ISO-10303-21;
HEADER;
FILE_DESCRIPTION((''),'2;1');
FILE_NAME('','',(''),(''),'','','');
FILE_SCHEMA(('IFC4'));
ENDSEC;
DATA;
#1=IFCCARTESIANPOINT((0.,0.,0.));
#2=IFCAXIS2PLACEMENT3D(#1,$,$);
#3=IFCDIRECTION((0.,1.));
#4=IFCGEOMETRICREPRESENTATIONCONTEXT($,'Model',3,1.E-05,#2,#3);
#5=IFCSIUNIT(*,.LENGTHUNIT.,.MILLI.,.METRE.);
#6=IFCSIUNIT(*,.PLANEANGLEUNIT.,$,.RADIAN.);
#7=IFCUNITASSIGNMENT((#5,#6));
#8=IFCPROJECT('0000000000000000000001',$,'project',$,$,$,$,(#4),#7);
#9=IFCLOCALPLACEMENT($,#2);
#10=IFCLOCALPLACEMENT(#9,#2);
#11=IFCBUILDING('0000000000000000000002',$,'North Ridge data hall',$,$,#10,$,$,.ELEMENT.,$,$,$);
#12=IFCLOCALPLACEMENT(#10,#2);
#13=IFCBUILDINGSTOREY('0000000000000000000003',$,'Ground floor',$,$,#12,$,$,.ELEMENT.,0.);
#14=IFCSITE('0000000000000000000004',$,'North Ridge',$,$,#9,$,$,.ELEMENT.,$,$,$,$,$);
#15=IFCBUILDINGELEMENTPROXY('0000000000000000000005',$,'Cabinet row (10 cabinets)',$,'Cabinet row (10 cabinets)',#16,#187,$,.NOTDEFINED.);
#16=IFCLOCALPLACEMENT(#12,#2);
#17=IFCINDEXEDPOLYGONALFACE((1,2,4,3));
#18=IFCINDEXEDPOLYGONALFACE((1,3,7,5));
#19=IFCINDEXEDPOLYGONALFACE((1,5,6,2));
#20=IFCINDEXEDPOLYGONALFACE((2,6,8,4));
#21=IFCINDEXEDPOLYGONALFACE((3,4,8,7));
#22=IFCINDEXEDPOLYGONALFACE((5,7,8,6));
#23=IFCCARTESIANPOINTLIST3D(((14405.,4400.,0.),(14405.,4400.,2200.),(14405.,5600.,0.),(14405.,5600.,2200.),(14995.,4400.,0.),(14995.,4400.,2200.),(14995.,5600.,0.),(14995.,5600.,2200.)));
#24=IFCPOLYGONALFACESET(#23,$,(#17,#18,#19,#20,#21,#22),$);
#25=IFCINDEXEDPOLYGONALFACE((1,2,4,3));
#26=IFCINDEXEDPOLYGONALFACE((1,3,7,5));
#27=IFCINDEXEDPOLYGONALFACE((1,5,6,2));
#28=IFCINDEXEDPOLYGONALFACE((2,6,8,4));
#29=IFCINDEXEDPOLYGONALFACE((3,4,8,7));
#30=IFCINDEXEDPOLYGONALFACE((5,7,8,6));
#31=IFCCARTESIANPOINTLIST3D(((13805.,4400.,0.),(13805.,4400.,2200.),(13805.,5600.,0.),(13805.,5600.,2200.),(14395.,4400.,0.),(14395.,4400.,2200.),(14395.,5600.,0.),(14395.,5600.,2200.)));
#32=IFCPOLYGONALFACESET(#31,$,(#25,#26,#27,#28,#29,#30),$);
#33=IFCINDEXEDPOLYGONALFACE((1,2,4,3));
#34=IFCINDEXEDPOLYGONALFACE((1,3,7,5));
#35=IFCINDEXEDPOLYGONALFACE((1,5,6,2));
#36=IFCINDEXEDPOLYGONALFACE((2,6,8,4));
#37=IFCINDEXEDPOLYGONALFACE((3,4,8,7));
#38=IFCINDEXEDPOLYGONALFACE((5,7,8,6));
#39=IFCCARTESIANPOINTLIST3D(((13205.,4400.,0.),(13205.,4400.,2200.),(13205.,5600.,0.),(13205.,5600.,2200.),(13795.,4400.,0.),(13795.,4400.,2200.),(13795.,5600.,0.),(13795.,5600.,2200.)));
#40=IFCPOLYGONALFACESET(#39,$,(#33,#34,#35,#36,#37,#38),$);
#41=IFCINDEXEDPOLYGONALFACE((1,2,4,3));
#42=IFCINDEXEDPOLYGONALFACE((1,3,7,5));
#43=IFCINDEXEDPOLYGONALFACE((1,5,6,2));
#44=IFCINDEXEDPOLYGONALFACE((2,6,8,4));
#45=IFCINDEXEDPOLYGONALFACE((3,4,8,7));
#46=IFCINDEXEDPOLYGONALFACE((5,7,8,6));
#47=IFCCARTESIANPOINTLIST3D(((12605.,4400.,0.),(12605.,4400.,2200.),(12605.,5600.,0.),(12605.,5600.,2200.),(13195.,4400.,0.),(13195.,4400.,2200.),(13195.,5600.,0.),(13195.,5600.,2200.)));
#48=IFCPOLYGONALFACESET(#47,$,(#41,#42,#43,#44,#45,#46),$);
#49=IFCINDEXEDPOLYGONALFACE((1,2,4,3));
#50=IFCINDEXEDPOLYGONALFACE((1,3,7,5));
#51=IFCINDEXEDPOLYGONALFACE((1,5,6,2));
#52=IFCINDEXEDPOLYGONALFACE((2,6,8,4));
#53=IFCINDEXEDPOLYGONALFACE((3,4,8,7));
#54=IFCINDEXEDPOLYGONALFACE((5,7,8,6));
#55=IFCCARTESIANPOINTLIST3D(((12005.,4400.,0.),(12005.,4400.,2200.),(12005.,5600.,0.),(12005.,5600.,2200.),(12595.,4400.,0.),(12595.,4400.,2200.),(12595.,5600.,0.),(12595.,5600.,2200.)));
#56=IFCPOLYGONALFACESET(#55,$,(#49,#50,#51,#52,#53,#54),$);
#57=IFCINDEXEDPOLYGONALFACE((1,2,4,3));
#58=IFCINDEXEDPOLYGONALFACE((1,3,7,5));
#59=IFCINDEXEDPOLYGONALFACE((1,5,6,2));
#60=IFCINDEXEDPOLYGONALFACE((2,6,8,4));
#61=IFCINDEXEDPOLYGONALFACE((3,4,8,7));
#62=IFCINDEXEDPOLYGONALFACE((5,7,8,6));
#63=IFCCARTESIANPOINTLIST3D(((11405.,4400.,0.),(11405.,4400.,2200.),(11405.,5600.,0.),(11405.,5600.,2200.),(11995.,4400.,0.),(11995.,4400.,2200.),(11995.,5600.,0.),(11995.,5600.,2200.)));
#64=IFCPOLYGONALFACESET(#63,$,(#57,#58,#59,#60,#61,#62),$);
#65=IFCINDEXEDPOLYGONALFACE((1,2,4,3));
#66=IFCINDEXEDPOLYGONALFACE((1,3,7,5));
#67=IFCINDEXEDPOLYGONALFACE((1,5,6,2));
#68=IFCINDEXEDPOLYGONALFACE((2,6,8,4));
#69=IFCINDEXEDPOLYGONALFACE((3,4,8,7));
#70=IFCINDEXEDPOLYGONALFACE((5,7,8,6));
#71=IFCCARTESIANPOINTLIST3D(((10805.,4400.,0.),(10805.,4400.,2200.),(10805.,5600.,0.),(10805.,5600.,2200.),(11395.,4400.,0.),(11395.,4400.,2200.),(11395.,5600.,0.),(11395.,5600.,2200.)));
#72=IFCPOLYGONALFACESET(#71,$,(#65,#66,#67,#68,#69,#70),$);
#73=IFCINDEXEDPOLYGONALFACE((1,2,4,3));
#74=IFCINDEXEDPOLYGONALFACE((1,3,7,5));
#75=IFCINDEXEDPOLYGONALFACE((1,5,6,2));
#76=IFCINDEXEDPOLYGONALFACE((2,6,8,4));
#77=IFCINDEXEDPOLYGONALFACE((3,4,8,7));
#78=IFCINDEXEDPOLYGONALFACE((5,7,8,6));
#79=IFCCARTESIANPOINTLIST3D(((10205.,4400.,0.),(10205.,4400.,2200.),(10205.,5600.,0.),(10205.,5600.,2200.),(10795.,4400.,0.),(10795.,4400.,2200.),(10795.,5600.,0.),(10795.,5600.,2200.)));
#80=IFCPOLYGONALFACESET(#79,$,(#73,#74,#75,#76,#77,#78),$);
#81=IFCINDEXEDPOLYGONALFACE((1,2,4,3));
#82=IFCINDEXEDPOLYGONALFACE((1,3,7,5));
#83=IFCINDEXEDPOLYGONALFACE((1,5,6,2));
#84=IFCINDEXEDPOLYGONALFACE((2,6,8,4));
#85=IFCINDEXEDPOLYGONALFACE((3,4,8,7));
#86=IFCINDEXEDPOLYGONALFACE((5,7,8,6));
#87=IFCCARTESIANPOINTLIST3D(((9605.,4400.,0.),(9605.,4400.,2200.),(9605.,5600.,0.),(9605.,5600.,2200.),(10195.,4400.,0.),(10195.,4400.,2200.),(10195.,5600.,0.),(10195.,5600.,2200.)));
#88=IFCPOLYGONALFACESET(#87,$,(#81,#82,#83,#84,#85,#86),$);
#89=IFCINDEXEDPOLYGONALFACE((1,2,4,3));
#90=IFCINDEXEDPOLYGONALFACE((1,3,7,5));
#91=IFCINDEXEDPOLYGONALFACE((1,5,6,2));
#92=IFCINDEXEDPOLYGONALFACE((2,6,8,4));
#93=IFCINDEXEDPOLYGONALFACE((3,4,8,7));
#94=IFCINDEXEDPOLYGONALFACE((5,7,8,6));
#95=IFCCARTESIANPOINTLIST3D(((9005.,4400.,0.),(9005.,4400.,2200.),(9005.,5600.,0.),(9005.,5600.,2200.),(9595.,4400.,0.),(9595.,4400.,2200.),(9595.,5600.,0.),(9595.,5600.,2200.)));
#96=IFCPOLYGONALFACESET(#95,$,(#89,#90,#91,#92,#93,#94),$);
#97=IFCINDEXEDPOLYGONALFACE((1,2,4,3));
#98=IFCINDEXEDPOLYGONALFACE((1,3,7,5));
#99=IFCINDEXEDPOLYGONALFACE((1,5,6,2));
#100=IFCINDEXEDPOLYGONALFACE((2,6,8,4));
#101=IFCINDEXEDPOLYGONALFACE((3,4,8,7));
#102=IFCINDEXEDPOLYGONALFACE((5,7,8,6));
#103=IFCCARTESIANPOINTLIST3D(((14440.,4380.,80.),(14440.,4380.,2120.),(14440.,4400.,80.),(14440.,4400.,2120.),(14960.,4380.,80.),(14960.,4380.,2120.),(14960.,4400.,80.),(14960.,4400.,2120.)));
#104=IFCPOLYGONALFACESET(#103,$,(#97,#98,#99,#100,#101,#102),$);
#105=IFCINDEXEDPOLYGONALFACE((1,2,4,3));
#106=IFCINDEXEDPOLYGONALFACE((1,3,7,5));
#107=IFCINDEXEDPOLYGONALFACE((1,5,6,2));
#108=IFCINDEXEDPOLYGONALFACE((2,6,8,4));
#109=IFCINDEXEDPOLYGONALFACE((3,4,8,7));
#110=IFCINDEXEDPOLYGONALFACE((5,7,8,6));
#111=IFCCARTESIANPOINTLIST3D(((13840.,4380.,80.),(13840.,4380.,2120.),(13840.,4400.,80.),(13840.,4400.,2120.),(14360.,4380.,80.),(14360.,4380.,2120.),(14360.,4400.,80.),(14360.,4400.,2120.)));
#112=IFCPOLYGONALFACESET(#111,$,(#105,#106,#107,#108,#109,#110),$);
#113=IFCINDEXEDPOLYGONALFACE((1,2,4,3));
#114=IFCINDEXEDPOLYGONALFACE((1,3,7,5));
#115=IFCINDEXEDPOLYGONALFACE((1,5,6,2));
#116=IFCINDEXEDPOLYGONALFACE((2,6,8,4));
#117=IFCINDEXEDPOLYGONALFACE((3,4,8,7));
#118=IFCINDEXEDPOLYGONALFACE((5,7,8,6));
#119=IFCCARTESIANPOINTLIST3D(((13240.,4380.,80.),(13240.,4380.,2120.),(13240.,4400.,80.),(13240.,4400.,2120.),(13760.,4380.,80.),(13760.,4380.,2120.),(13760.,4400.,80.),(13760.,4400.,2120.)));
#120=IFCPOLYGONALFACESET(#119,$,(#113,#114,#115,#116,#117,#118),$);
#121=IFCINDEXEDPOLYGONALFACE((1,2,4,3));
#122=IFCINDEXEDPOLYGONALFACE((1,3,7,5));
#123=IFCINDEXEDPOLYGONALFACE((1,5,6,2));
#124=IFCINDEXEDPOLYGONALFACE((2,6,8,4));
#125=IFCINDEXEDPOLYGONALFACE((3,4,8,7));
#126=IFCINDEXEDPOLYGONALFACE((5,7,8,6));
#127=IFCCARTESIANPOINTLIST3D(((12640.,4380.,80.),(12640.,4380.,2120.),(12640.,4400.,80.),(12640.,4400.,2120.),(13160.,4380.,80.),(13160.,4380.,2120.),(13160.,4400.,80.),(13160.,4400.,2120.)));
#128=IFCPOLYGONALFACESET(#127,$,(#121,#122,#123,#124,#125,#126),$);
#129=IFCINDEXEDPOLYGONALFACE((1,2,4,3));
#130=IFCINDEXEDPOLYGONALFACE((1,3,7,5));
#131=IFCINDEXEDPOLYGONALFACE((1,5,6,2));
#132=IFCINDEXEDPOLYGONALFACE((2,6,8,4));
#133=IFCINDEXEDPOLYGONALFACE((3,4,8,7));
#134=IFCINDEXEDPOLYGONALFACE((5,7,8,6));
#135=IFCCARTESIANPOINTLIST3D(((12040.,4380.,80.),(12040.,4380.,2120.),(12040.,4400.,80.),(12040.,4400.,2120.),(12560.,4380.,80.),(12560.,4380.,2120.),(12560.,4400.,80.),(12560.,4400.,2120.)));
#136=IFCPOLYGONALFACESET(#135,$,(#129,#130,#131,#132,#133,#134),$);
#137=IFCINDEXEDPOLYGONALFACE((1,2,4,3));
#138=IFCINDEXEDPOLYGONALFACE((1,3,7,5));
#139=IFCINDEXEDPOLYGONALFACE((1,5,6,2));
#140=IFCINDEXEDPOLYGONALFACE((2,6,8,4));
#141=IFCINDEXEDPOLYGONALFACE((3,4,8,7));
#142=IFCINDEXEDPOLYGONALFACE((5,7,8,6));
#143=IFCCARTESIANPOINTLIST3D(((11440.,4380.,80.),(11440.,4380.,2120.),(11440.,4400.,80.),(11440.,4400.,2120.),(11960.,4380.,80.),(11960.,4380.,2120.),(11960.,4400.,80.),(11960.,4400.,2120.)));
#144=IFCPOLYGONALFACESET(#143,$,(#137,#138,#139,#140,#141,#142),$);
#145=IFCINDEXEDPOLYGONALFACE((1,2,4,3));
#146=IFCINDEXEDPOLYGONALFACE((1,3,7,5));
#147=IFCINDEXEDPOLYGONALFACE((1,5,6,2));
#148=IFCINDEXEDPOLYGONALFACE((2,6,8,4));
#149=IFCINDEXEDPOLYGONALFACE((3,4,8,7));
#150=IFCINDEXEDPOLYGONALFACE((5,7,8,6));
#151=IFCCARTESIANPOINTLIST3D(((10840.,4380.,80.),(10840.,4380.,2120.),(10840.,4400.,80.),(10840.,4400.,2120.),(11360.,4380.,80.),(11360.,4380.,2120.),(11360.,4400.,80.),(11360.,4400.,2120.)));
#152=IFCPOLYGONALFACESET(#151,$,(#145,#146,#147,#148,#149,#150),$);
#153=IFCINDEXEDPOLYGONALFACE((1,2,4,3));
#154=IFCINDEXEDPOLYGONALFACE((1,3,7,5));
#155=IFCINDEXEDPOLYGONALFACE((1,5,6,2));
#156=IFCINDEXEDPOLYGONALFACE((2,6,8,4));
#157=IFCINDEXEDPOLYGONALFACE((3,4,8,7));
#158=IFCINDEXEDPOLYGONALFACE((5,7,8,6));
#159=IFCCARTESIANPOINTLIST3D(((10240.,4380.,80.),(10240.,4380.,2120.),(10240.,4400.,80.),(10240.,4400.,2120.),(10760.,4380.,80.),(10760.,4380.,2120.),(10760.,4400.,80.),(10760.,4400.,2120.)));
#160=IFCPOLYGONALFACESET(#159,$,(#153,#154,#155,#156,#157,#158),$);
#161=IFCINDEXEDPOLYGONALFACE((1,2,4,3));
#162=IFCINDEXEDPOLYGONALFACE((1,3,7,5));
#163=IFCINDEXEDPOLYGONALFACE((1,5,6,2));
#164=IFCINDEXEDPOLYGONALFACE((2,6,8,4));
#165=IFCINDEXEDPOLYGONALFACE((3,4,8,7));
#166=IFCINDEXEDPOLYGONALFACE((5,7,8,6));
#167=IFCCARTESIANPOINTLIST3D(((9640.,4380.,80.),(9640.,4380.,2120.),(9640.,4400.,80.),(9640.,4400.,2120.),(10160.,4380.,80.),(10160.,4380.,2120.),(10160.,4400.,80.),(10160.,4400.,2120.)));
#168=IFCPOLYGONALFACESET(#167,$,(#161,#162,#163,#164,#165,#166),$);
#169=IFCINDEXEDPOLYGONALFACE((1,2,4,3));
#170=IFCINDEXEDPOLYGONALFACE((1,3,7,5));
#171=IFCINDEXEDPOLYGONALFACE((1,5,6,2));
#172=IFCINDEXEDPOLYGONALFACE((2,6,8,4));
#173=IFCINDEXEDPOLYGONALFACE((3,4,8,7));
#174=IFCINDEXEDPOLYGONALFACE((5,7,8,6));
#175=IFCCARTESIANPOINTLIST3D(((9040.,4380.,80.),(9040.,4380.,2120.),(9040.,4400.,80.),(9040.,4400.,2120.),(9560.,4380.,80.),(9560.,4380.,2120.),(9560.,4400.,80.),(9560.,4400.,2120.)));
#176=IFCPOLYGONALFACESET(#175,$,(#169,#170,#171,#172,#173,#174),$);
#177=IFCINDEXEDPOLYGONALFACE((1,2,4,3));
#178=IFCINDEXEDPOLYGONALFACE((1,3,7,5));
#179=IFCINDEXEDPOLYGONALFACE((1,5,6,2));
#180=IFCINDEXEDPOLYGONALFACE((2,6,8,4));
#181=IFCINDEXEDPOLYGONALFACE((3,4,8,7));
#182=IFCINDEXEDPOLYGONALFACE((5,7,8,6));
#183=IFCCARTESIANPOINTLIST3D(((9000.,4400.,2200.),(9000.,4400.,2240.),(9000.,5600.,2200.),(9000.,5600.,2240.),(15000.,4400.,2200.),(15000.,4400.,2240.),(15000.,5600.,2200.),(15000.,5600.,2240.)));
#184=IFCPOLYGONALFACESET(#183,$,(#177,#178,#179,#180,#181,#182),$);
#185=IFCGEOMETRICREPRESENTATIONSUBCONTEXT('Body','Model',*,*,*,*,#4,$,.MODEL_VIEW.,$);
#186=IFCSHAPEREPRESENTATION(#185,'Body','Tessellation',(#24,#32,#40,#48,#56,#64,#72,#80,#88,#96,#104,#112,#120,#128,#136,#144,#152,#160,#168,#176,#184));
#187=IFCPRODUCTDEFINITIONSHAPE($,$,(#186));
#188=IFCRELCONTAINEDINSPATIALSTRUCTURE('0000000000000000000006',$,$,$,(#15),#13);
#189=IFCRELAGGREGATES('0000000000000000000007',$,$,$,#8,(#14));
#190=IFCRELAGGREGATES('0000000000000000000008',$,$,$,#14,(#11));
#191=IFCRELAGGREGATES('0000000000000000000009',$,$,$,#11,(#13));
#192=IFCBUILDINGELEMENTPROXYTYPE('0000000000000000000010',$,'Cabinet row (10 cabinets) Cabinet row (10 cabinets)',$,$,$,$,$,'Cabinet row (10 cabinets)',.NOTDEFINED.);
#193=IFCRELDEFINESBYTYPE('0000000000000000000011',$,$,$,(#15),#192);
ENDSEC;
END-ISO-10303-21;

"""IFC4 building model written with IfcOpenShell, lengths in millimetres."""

from ifc_helpers import new_model, si_unit, direction, frame, origin, place, context, subcontext, project, spatial, polyline, outline, extrude, source, transform, mapped, type_object, type_shapes, element, save


model = new_model("IFC4")

# Units and contexts
model_context = context("Model", 3, precision=1e-05, world=origin(), true_north=direction((0.0, 1.0)))
body_context = subcontext(model_context, "Body", "Model", "MODEL_VIEW")
ifc_project = project(units=[si_unit("LENGTHUNIT", "METRE", prefix="MILLI"), si_unit("PLANEANGLEUNIT", "RADIAN")], contexts=[model_context])

# Site, building, storey
site_placement = place(None, origin())
site = spatial("IfcSite", under=ifc_project, at=site_placement, Name="North Ridge", CompositionType="ELEMENT")
building_placement = place(site_placement, origin())
building = spatial("IfcBuilding", under=site, at=building_placement, Name="North Ridge data hall", CompositionType="ELEMENT")
storey_placement = place(building_placement, origin())
storey = spatial("IfcBuildingStorey", under=building, at=storey_placement, Name="Ground floor", CompositionType="ELEMENT", Elevation=0.0)

# Building element proxy
building_element_proxy_type_1 = type_object("IfcBuildingElementProxyType", Name="Cabinet row (10 cabinets) Cabinet row (10 cabinets)", ElementType="Cabinet row (10 cabinets)", PredefinedType="NOTDEFINED")
shared_shape_1 = source(origin(), body_context, "Body", "SweptSolid", [
    extrude(outline(polyline([(5.0, 0.0), (595.0, 0.0), (595.0, 1200.0), (5.0, 1200.0), (5.0, 0.0)])), origin(), (0.0, 0.0, 1.0), 2200.0),
    extrude(outline(polyline([(605.0, 0.0), (1195.0, 0.0), (1195.0, 1200.0), (605.0, 1200.0), (605.0, 0.0)])), origin(), (0.0, 0.0, 1.0), 2200.0),
    extrude(outline(polyline([(1205.0, 0.0), (1795.0, 0.0), (1795.0, 1200.0), (1205.0, 1200.0), (1205.0, 0.0)])), origin(), (0.0, 0.0, 1.0), 2200.0),
    extrude(outline(polyline([(1805.0, 0.0), (2395.0, 0.0), (2395.0, 1200.0), (1805.0, 1200.0), (1805.0, 0.0)])), origin(), (0.0, 0.0, 1.0), 2200.0),
    extrude(outline(polyline([(2405.0, 0.0), (2995.0, 0.0), (2995.0, 1200.0), (2405.0, 1200.0), (2405.0, 0.0)])), origin(), (0.0, 0.0, 1.0), 2200.0),
    extrude(outline(polyline([(3005.0, 0.0), (3595.0, 0.0), (3595.0, 1200.0), (3005.0, 1200.0), (3005.0, 0.0)])), origin(), (0.0, 0.0, 1.0), 2200.0),
    extrude(outline(polyline([(3605.0, 0.0), (4195.0, 0.0), (4195.0, 1200.0), (3605.0, 1200.0), (3605.0, 0.0)])), origin(), (0.0, 0.0, 1.0), 2200.0),
    extrude(outline(polyline([(4205.0, 0.0), (4795.0, 0.0), (4795.0, 1200.0), (4205.0, 1200.0), (4205.0, 0.0)])), origin(), (0.0, 0.0, 1.0), 2200.0),
    extrude(outline(polyline([(4805.0, 0.0), (5395.0, 0.0), (5395.0, 1200.0), (4805.0, 1200.0), (4805.0, 0.0)])), origin(), (0.0, 0.0, 1.0), 2200.0),
    extrude(outline(polyline([(5405.0, 0.0), (5995.0, 0.0), (5995.0, 1200.0), (5405.0, 1200.0), (5405.0, 0.0)])), origin(), (0.0, 0.0, 1.0), 2200.0),
    extrude(outline(polyline([(40.0, 1200.0), (560.0, 1200.0), (560.0, 1220.0), (40.0, 1220.0), (40.0, 1200.0)])), frame((0.0, 0.0, 80.0)), (0.0, 0.0, 1.0), 2040.0),
    extrude(outline(polyline([(640.0, 1200.0), (1160.0, 1200.0), (1160.0, 1220.0), (640.0, 1220.0), (640.0, 1200.0)])), frame((0.0, 0.0, 80.0)), (0.0, 0.0, 1.0), 2040.0),
    extrude(outline(polyline([(1240.0, 1200.0), (1760.0, 1200.0), (1760.0, 1220.0), (1240.0, 1220.0), (1240.0, 1200.0)])), frame((0.0, 0.0, 80.0)), (0.0, 0.0, 1.0), 2040.0),
    extrude(outline(polyline([(1840.0, 1200.0), (2360.0, 1200.0), (2360.0, 1220.0), (1840.0, 1220.0), (1840.0, 1200.0)])), frame((0.0, 0.0, 80.0)), (0.0, 0.0, 1.0), 2040.0),
    extrude(outline(polyline([(2440.0, 1200.0), (2960.0, 1200.0), (2960.0, 1220.0), (2440.0, 1220.0), (2440.0, 1200.0)])), frame((0.0, 0.0, 80.0)), (0.0, 0.0, 1.0), 2040.0),
    extrude(outline(polyline([(3040.0, 1200.0), (3560.0, 1200.0), (3560.0, 1220.0), (3040.0, 1220.0), (3040.0, 1200.0)])), frame((0.0, 0.0, 80.0)), (0.0, 0.0, 1.0), 2040.0),
    extrude(outline(polyline([(3640.0, 1200.0), (4160.0, 1200.0), (4160.0, 1220.0), (3640.0, 1220.0), (3640.0, 1200.0)])), frame((0.0, 0.0, 80.0)), (0.0, 0.0, 1.0), 2040.0),
    extrude(outline(polyline([(4240.0, 1200.0), (4760.0, 1200.0), (4760.0, 1220.0), (4240.0, 1220.0), (4240.0, 1200.0)])), frame((0.0, 0.0, 80.0)), (0.0, 0.0, 1.0), 2040.0),
    extrude(outline(polyline([(4840.0, 1200.0), (5360.0, 1200.0), (5360.0, 1220.0), (4840.0, 1220.0), (4840.0, 1200.0)])), frame((0.0, 0.0, 80.0)), (0.0, 0.0, 1.0), 2040.0),
    extrude(outline(polyline([(5440.0, 1200.0), (5960.0, 1200.0), (5960.0, 1220.0), (5440.0, 1220.0), (5440.0, 1200.0)])), frame((0.0, 0.0, 80.0)), (0.0, 0.0, 1.0), 2040.0),
    extrude(outline(polyline([(0.0, 0.0), (6000.0, 0.0), (6000.0, 1200.0), (0.0, 1200.0), (0.0, 0.0)])), frame((0.0, 0.0, 2200.0)), (0.0, 0.0, 1.0), 40.0),
])
type_shapes(building_element_proxy_type_1, [shared_shape_1])
for number, where, z_axis, x_axis, name in (
    (1, (15000.0, 5600.0, 0.0), (0.0, 0.0, 1.0), (-1.0, 0.0, 0.0), "Cabinet row (10 cabinets)"),
):
    element("IfcBuildingElementProxy", number, at=place(storey_placement, frame(where, z_axis=z_axis, x_axis=x_axis)), inside=storey, type_object=building_element_proxy_type_1, Name=name, ObjectType="Cabinet row (10 cabinets)", PredefinedType="NOTDEFINED", context=body_context, shape_type="MappedRepresentation", body=[
        mapped(shared_shape_1, transform((0.0, 0.0, 0.0))),
    ])

save(model, "model.ifc")
